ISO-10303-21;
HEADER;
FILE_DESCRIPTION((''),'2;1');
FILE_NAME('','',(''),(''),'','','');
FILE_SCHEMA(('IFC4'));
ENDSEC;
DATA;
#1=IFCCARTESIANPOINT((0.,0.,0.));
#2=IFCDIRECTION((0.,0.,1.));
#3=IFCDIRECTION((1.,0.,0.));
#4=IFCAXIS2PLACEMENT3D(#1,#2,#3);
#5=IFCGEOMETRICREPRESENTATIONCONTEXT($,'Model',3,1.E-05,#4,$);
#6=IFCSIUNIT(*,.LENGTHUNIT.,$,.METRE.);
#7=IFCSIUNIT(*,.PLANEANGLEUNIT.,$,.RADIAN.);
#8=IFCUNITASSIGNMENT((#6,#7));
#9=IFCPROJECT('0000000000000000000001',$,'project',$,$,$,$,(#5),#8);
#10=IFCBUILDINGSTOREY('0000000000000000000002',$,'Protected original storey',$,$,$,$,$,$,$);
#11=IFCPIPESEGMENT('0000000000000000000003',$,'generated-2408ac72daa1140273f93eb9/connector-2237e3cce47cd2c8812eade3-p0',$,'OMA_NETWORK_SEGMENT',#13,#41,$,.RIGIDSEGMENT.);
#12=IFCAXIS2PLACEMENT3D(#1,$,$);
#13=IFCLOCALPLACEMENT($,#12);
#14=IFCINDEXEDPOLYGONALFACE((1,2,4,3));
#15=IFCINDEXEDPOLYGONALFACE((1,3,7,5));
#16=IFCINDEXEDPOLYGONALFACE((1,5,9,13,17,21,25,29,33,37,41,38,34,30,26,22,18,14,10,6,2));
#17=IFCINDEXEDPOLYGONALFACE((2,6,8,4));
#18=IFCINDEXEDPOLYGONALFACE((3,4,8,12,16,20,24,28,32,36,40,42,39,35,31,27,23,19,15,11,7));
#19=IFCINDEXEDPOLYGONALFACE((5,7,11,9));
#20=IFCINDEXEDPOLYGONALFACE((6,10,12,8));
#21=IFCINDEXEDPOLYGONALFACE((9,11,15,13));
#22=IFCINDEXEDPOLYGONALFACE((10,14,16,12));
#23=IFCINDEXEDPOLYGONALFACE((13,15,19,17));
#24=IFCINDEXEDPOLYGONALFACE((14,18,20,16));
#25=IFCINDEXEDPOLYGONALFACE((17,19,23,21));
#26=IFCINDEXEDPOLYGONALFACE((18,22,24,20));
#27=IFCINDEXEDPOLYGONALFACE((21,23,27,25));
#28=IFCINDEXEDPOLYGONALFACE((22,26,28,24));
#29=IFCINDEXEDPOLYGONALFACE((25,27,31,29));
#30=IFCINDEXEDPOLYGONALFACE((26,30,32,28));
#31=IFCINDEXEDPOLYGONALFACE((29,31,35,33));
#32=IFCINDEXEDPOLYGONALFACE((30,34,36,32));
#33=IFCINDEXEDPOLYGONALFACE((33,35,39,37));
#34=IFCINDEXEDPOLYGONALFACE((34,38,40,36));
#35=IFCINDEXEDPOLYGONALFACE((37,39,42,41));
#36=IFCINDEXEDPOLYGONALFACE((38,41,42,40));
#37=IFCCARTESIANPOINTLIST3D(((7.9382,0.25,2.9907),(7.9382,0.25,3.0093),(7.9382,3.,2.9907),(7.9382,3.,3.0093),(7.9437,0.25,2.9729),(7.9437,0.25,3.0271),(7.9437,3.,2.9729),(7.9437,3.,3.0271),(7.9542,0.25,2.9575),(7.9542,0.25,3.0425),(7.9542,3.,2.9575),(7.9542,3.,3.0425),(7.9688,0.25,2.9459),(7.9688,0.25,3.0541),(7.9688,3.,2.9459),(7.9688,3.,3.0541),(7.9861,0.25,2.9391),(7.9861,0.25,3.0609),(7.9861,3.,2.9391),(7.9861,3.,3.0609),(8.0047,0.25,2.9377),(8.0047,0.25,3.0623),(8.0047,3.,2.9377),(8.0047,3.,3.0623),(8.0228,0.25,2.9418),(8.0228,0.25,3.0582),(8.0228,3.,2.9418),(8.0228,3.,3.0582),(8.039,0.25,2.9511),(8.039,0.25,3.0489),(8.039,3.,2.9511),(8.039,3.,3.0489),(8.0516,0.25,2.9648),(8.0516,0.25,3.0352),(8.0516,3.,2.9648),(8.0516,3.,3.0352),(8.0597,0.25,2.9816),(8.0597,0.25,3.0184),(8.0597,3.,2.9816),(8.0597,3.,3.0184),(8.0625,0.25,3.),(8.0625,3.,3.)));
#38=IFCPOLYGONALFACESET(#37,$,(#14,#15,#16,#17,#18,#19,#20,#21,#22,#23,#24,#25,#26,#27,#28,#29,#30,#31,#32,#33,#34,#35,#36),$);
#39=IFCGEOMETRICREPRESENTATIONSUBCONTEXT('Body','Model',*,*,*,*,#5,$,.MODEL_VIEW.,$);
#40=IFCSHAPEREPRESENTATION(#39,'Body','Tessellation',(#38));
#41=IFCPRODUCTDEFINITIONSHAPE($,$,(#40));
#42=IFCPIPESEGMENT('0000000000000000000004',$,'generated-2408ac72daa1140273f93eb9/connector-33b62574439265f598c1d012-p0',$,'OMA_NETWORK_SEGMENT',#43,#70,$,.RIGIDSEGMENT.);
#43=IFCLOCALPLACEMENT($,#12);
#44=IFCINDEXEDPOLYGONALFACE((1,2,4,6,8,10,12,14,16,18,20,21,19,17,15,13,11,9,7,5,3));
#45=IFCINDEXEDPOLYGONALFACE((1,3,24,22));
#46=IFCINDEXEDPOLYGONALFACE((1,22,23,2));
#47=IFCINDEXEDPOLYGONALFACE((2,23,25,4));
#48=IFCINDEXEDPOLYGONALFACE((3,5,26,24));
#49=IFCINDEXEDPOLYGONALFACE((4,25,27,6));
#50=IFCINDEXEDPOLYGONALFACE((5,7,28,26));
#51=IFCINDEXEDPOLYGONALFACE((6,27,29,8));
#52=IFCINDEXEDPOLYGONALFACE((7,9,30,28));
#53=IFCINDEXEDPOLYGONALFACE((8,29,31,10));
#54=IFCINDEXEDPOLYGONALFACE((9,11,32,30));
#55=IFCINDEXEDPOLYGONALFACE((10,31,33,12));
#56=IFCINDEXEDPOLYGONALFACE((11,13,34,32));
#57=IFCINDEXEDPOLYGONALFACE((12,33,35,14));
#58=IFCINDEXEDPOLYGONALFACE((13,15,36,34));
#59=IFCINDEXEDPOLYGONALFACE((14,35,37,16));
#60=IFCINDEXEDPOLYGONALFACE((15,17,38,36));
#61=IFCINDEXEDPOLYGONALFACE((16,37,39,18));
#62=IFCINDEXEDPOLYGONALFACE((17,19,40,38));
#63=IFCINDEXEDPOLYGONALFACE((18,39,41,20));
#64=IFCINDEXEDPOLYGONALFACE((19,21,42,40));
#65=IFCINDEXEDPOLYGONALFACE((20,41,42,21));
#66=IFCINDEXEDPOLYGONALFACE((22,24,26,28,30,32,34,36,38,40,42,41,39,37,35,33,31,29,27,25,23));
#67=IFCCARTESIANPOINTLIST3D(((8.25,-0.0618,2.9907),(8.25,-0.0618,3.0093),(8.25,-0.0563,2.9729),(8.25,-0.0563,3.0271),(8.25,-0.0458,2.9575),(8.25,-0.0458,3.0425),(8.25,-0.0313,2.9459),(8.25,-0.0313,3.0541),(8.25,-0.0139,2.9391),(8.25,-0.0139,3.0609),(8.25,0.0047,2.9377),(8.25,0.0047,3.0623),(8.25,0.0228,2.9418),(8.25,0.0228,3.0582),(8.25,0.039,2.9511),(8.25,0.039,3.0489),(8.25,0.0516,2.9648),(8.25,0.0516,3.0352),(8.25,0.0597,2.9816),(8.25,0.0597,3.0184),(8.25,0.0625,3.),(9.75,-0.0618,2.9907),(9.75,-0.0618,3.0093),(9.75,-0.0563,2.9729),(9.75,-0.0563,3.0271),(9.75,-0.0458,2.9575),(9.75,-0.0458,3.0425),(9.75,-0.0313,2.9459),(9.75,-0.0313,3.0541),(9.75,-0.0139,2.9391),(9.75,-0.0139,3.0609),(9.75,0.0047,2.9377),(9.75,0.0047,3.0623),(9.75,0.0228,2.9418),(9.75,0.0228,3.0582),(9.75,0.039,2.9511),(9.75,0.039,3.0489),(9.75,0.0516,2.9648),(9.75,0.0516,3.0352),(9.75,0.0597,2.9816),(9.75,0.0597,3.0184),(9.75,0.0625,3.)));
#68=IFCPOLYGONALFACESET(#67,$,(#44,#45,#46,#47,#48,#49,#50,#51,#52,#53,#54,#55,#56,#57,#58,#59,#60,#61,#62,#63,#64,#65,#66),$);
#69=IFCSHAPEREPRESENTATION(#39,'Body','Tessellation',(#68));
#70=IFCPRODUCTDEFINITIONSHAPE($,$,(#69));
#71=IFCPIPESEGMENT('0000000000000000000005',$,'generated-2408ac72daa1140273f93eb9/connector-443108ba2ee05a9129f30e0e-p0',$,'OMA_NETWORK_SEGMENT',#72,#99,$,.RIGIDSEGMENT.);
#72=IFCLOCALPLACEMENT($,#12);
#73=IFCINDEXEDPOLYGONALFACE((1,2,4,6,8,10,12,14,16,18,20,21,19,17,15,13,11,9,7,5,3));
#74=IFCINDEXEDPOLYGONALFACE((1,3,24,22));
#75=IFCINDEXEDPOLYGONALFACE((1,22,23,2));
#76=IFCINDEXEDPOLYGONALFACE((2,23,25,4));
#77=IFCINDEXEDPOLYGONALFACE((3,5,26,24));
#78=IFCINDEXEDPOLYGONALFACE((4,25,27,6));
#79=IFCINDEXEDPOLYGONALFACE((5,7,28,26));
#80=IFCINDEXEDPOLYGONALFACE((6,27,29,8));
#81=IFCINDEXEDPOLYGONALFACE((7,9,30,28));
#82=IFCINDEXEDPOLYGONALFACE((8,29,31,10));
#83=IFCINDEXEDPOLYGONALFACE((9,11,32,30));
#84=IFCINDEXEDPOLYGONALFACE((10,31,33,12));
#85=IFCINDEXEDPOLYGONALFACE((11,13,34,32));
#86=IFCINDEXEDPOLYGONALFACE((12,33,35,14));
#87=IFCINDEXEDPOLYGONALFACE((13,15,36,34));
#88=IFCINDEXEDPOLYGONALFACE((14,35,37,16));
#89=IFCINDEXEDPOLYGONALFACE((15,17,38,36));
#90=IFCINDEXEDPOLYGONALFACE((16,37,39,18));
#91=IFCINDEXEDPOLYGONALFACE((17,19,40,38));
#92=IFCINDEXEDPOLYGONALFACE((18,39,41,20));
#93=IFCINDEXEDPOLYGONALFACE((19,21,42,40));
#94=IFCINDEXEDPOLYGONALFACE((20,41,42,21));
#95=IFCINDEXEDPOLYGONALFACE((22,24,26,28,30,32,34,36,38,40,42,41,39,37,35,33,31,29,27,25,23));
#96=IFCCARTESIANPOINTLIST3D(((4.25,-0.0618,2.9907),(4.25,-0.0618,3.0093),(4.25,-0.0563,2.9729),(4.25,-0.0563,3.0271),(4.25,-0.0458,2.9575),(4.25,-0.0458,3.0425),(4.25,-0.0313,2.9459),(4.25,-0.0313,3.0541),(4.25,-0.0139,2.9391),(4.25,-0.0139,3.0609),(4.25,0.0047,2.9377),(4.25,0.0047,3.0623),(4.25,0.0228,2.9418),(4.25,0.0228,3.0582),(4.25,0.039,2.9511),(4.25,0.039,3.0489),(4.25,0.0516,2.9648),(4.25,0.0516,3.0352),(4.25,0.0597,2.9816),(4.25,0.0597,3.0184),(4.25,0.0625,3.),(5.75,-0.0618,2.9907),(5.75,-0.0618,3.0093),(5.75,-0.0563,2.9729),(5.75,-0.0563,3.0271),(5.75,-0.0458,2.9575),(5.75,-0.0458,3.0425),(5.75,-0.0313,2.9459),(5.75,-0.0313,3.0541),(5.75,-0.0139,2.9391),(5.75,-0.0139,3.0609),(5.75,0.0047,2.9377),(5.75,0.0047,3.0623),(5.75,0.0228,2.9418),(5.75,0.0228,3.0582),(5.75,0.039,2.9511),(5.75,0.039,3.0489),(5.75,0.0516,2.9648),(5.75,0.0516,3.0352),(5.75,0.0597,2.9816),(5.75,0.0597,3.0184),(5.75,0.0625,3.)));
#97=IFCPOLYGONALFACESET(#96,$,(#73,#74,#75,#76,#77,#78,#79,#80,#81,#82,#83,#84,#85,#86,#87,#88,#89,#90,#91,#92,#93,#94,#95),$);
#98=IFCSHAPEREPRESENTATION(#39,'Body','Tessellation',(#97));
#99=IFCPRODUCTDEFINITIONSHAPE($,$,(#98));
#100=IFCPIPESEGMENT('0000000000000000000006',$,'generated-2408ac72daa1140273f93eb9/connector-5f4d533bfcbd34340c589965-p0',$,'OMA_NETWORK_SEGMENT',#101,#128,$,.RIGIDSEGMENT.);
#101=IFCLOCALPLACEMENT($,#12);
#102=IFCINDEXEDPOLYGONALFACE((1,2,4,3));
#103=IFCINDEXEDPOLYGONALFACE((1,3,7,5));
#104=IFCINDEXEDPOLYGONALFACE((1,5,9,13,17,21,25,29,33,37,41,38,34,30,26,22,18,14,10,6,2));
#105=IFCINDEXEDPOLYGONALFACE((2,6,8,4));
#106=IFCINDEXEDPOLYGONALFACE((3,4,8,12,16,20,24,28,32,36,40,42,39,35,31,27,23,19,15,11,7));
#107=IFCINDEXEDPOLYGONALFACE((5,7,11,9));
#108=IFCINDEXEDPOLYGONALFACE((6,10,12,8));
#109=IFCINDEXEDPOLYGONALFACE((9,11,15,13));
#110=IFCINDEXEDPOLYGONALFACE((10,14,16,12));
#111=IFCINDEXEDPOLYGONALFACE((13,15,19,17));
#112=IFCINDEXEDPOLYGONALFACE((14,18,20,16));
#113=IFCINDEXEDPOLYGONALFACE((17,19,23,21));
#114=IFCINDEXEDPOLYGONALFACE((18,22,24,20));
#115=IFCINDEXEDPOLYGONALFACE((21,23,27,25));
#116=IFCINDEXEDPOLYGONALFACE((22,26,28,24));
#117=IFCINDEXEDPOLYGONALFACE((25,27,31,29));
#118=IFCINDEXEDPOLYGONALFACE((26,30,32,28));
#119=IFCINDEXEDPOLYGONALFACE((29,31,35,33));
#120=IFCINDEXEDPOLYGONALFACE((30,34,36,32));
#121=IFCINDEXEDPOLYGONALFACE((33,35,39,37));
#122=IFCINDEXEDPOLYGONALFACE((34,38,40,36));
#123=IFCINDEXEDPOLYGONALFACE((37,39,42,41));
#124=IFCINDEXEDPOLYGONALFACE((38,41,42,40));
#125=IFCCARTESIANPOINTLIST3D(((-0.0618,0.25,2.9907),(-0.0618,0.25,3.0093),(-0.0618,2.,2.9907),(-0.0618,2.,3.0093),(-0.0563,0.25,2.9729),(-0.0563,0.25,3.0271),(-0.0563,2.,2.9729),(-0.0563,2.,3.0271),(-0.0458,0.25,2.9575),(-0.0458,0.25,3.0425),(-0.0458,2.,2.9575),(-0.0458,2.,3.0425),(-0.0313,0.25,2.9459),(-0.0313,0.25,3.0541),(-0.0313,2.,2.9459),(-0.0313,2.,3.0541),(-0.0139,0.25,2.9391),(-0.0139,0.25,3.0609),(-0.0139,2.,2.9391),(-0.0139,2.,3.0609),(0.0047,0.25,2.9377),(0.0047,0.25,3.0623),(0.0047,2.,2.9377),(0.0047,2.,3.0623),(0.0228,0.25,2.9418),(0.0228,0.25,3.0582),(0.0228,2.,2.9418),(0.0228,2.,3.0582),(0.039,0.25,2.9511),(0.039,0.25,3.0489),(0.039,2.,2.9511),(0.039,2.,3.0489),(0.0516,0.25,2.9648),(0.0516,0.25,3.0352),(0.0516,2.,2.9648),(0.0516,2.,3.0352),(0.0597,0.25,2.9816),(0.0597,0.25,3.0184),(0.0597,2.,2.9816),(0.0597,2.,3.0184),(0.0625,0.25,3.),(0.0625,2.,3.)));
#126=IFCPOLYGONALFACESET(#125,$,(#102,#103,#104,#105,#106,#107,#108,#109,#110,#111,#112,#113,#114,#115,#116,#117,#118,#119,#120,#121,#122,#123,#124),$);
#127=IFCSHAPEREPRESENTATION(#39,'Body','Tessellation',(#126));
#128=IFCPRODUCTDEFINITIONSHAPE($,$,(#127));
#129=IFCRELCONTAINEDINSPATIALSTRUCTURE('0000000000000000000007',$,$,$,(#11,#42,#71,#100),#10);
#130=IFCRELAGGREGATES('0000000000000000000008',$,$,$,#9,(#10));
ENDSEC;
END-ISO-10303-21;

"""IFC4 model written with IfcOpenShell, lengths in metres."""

from ifc_helpers import new_model, si_unit, frame, origin_with_axes, origin_2d, place, context, subcontext, project, spatial, circle, extrude, element, save


model = new_model("IFC4")

# Units and contexts
model_context = context("Model", 3, precision=1e-05, world=origin_with_axes())
body_context = subcontext(model_context, "Body", "Model", "MODEL_VIEW")
ifc_project = project(units=[si_unit("LENGTHUNIT", "METRE"), si_unit("PLANEANGLEUNIT", "RADIAN")], contexts=[model_context])

# Storey
storey = spatial("IfcBuildingStorey", under=ifc_project, Name="Protected original storey")

# Pipe segments
pipe_segment_1_placement = place(None, origin_with_axes())
element("IfcPipeSegment", 1, at=pipe_segment_1_placement, inside=storey, Name="generated-2408ac72daa1140273f93eb9/connector-2237e3cce47cd2c8812eade3-p0", ObjectType="OMA_NETWORK_SEGMENT", PredefinedType="RIGIDSEGMENT", context=body_context, shape_type="SweptSolid", body=[
    extrude(circle(Radius=0.0625, at=origin_2d()), frame((8.0, 0.25, 3.0), z_axis=(0.0, 1.0, 0.0), x_axis=(1.0, 0.0, 0.0)), (0.0, 0.0, 1.0), 2.75),
])
pipe_segment_2_placement = place(None, origin_with_axes())
element("IfcPipeSegment", 2, at=pipe_segment_2_placement, inside=storey, Name="generated-2408ac72daa1140273f93eb9/connector-33b62574439265f598c1d012-p0", ObjectType="OMA_NETWORK_SEGMENT", PredefinedType="RIGIDSEGMENT", context=body_context, shape_type="SweptSolid", body=[
    extrude(circle(Radius=0.0625, at=origin_2d()), frame((8.25, 0.0, 3.0), z_axis=(1.0, 0.0, 0.0), x_axis=(0.0, 1.0, 0.0)), (0.0, 0.0, 1.0), 1.5),
])
pipe_segment_3_placement = place(None, origin_with_axes())
element("IfcPipeSegment", 3, at=pipe_segment_3_placement, inside=storey, Name="generated-2408ac72daa1140273f93eb9/connector-443108ba2ee05a9129f30e0e-p0", ObjectType="OMA_NETWORK_SEGMENT", PredefinedType="RIGIDSEGMENT", context=body_context, shape_type="SweptSolid", body=[
    extrude(circle(Radius=0.0625, at=origin_2d()), frame((4.25, 0.0, 3.0), z_axis=(1.0, 0.0, 0.0), x_axis=(0.0, 1.0, 0.0)), (0.0, 0.0, 1.0), 1.5),
])
pipe_segment_4_placement = place(None, origin_with_axes())
element("IfcPipeSegment", 4, at=pipe_segment_4_placement, inside=storey, Name="generated-2408ac72daa1140273f93eb9/connector-5f4d533bfcbd34340c589965-p0", ObjectType="OMA_NETWORK_SEGMENT", PredefinedType="RIGIDSEGMENT", context=body_context, shape_type="SweptSolid", body=[
    extrude(circle(Radius=0.0625, at=origin_2d()), frame((0.0, 0.25, 3.0), z_axis=(0.0, 1.0, 0.0), x_axis=(1.0, 0.0, 0.0)), (0.0, 0.0, 1.0), 1.75),
])

save(model, "model.ifc")
